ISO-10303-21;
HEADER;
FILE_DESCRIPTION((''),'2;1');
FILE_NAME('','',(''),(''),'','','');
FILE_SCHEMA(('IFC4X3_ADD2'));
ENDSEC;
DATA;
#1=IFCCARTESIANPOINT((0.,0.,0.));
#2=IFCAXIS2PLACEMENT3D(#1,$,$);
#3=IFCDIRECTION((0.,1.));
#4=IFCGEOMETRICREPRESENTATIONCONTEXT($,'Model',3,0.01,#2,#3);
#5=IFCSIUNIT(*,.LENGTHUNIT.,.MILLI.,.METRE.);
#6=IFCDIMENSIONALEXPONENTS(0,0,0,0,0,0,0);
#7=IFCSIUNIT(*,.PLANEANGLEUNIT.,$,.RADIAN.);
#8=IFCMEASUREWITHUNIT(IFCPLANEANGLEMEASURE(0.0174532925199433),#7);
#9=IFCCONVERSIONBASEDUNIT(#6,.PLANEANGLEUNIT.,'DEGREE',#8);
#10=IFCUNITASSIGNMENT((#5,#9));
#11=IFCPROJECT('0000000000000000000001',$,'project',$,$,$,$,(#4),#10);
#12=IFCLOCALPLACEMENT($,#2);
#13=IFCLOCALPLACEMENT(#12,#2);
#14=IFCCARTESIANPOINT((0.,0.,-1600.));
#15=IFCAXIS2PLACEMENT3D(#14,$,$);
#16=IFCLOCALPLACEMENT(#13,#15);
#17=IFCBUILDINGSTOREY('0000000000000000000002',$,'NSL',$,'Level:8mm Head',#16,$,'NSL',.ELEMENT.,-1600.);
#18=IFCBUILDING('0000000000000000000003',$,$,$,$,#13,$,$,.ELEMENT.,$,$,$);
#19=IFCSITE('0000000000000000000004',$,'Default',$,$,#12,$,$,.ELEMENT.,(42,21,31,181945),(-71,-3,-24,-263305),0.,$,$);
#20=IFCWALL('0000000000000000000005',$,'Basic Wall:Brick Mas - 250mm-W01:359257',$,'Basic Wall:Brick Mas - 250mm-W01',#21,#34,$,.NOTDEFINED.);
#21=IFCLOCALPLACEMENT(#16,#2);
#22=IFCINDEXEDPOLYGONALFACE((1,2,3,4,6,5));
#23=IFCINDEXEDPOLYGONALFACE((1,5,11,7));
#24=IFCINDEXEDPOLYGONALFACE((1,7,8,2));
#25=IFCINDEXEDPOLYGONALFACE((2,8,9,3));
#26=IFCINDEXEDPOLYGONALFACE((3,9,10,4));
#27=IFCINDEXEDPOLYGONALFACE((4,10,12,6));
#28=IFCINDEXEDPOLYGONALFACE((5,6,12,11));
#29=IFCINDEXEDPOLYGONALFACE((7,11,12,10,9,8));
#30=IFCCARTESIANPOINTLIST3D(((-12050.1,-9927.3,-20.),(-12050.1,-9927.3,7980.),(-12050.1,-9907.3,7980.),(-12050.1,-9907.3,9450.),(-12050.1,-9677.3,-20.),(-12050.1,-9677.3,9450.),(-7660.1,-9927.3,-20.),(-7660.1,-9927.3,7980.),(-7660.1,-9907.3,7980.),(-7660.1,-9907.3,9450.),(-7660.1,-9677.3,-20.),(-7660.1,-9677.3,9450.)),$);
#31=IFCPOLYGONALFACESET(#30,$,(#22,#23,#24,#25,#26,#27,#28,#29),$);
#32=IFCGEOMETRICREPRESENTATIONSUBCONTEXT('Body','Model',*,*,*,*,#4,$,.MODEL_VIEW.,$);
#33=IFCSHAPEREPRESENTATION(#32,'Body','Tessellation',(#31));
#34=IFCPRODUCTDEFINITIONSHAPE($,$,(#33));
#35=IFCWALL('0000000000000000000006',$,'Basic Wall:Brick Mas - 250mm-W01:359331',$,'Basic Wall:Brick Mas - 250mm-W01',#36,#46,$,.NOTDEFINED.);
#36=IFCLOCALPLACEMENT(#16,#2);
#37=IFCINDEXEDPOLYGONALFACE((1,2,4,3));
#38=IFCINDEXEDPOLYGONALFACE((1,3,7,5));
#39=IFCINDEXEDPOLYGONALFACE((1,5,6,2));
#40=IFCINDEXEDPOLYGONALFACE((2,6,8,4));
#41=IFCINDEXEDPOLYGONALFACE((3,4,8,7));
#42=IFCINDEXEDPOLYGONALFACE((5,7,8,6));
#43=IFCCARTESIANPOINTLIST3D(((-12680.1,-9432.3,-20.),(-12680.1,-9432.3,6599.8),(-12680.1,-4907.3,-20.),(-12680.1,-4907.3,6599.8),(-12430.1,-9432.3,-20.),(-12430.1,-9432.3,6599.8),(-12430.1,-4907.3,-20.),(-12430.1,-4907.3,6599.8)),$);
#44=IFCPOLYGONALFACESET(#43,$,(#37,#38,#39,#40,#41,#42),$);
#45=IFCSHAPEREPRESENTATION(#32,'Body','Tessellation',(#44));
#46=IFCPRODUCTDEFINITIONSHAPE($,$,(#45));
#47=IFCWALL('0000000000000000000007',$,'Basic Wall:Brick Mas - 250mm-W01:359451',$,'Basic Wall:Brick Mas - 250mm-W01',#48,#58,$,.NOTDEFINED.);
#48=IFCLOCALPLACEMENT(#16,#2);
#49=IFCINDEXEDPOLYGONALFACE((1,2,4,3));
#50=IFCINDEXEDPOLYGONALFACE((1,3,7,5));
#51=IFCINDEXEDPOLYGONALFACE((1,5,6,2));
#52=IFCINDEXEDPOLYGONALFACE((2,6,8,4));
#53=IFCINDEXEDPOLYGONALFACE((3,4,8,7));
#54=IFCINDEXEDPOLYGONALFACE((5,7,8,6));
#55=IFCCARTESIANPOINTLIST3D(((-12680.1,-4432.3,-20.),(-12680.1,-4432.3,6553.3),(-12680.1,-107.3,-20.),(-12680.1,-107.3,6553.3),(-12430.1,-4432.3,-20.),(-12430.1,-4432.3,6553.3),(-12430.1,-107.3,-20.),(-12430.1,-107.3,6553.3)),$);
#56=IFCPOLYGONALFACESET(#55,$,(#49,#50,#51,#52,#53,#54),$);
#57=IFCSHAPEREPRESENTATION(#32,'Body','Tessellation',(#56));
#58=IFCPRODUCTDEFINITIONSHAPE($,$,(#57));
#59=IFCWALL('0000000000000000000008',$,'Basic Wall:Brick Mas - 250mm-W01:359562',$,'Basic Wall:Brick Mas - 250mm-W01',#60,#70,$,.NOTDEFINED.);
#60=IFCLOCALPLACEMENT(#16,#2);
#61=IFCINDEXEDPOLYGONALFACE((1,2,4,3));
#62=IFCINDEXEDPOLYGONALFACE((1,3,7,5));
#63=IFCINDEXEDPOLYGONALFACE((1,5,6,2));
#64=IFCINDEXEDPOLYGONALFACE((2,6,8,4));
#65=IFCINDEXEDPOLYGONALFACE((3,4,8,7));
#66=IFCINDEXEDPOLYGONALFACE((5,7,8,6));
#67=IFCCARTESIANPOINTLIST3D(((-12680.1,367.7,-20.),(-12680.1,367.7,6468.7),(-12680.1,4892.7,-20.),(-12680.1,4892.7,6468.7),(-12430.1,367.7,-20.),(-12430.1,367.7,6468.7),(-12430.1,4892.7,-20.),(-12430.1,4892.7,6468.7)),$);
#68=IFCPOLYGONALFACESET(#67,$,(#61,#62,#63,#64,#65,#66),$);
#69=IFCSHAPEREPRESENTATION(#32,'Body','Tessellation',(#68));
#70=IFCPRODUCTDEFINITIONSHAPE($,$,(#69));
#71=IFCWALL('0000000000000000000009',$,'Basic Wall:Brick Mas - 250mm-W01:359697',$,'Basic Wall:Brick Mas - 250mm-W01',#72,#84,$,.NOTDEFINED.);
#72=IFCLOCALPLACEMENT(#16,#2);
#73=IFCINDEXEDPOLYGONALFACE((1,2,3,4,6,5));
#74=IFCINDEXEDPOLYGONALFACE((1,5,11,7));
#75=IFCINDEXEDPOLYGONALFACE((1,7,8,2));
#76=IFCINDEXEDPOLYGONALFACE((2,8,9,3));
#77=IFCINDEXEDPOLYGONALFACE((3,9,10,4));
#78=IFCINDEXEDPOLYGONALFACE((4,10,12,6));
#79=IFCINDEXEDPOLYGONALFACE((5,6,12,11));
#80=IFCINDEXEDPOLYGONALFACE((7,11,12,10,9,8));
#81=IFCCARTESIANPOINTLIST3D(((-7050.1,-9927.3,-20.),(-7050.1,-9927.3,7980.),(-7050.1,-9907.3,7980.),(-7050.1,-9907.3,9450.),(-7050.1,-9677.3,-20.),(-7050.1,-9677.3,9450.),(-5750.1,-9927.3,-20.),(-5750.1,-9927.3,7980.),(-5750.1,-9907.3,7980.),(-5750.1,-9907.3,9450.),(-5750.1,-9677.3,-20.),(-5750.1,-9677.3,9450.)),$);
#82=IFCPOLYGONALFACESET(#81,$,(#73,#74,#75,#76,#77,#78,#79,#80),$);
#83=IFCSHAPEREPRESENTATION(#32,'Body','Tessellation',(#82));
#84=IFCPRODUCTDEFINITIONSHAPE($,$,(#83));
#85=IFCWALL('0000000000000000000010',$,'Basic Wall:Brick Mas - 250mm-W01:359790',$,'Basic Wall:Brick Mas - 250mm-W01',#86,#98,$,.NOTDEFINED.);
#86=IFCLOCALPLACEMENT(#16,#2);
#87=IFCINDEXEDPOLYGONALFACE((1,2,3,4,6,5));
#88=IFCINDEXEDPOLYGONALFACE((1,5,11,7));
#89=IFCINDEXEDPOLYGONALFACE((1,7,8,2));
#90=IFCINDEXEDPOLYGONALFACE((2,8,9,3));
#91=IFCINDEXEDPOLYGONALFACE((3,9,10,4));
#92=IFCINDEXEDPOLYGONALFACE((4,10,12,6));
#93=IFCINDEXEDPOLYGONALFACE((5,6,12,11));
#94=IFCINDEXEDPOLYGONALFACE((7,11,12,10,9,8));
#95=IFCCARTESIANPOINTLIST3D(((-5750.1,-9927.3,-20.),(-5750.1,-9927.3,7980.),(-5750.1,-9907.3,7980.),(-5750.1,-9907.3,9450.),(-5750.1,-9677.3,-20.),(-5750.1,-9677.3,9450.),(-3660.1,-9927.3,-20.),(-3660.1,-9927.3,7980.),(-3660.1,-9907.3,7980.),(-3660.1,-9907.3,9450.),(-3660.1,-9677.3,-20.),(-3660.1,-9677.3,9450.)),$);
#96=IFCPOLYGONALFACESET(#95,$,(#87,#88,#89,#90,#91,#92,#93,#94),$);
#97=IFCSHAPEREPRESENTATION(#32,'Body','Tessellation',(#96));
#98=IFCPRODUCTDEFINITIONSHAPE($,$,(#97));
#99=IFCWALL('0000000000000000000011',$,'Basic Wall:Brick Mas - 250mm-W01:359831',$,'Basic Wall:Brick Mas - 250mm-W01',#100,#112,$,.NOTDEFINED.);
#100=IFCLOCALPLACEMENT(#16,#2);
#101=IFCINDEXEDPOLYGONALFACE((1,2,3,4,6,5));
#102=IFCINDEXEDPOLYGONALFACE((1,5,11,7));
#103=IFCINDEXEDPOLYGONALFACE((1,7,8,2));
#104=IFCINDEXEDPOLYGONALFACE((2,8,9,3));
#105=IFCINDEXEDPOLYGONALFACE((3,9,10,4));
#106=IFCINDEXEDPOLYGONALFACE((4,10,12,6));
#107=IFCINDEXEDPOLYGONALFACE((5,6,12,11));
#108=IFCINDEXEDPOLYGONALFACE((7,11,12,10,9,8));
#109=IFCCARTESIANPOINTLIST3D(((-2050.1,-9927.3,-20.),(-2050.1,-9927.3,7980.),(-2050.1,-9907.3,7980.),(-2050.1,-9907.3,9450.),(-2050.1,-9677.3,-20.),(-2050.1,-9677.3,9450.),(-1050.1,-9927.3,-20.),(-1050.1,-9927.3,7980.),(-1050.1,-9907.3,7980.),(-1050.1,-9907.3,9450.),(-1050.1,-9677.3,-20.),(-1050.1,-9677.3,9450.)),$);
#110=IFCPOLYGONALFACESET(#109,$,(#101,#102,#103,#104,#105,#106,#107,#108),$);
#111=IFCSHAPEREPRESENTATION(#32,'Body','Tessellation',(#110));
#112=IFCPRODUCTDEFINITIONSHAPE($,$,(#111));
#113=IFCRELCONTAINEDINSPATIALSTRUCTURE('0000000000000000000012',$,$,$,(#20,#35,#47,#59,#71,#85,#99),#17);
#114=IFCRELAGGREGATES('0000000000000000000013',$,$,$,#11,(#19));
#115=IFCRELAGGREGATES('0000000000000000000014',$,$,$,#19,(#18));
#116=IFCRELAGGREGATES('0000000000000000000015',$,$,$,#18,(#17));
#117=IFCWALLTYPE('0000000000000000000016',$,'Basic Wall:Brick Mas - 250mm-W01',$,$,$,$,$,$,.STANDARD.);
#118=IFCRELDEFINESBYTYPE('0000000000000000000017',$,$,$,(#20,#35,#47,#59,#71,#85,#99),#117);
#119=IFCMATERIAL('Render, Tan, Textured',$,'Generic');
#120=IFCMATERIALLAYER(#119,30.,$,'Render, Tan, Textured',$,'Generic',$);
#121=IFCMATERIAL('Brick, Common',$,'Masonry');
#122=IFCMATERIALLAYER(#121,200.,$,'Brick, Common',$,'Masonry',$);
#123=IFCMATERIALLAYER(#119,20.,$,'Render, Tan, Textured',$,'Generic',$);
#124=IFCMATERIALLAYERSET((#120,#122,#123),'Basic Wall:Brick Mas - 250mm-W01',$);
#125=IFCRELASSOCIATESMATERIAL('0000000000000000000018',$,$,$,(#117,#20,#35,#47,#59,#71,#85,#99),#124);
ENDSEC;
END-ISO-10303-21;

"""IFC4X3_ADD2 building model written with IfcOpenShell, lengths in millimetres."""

from ifc_helpers import new_model, entity, si_unit, converted_unit, direction, frame, frame_2d, origin, place, context, subcontext, project, spatial, polyline, rectangle, extrude, clip, bounded_halfspace, material, layer, layer_set, type_object, element, save


model = new_model("IFC4X3_ADD2")

# Units and contexts
model_context = context("Model", 3, precision=0.01, world=origin(), true_north=direction((0.0, 1.0)))
body_context = subcontext(model_context, "Body", "Model", "MODEL_VIEW")
ifc_project = project(units=[si_unit("LENGTHUNIT", "METRE", prefix="MILLI"), converted_unit("PLANEANGLEUNIT", "DEGREE", entity("IfcPlaneAngleMeasure", 0.0174532925199433), si_unit("PLANEANGLEUNIT", "RADIAN"), dimensions=[0, 0, 0, 0, 0, 0, 0])], contexts=[model_context])

# Site, building, storey
site_placement = place(None, origin())
site = spatial("IfcSite", under=ifc_project, at=site_placement, Name="Default", CompositionType="ELEMENT", RefLatitude=(42, 21, 31, 181945), RefLongitude=(-71, -3, -24, -263305), RefElevation=0.0)
building_placement = place(site_placement, origin())
building = spatial("IfcBuilding", under=site, at=building_placement, CompositionType="ELEMENT")
storey_placement = place(building_placement, frame((0.0, 0.0, -1600.0)))
storey = spatial("IfcBuildingStorey", under=building, at=storey_placement, Name="NSL", ObjectType="Level:8mm Head", LongName="NSL", CompositionType="ELEMENT", Elevation=-1600.0)

# Shared definitions
ifc_material_1 = material(Name="Render, Tan, Textured", Category="Generic")
ifc_layer_1 = layer(ifc_material_1, 30.0, Name="Render, Tan, Textured", Category="Generic")
ifc_material_2 = material(Name="Brick, Common", Category="Masonry")
ifc_layer_2 = layer(ifc_material_2, 200.0, Name="Brick, Common", Category="Masonry")
ifc_layer_3 = layer(ifc_material_1, 20.0, Name="Render, Tan, Textured", Category="Generic")
ifc_layer_set = layer_set([ifc_layer_1, ifc_layer_2, ifc_layer_3], Name="Basic Wall:Brick Mas - 250mm-W01")
wall_type = type_object("IfcWallType", Name="Basic Wall:Brick Mas - 250mm-W01", PredefinedType="STANDARD", material=ifc_layer_set)

# Walls
wall_1_placement = place(storey_placement, frame((-7660.1, -9802.3, -20.0), z_axis=(0.0, 0.0, 1.0), x_axis=(-1.0, 0.0, 0.0)))
element("IfcWall", 1, at=wall_1_placement, inside=storey, type_object=wall_type, material=ifc_layer_set, Name="Basic Wall:Brick Mas - 250mm-W01:359257", ObjectType="Basic Wall:Brick Mas - 250mm-W01", PredefinedType="NOTDEFINED", context=body_context, shape_type="Clipping", body=[
    clip(clip(extrude(rectangle(XDim=4390.0, YDim=250.0, at=frame_2d((2195.0, 0.0), x_axis=(-1.0, 0.0))), origin(), (0.0, 0.0, 1.0), 9470.0), bounded_halfspace(frame((0.0, -125.0, 9470.0), z_axis=(0.0, 0.0, -1.0), x_axis=(0.0, 1.0, 0.0)), True, frame((0.0, -125.0, 9470.0)), polyline([(0.0, 0.0), (4390.0, 0.0), (4390.0, 230.0), (0.0, 230.0), (0.0, 0.0)]))), bounded_halfspace(frame((4390.0, 105.0, 8000.0), z_axis=(0.0, 0.0, 1.0), x_axis=(0.0, 1.0, 0.0)), False, frame((4390.0, 105.0, 8000.0)), polyline([(0.0, 0.0), (0.0, 20.0), (-4390.0, 20.0), (-4390.0, 0.0), (0.0, 0.0)]))),
])
wall_2_placement = place(storey_placement, frame((-12555.1, -9432.3, -20.0), z_axis=(0.0, 0.0, 1.0), x_axis=(0.0, 1.0, 0.0)))
element("IfcWall", 2, at=wall_2_placement, inside=storey, type_object=wall_type, material=ifc_layer_set, Name="Basic Wall:Brick Mas - 250mm-W01:359331", ObjectType="Basic Wall:Brick Mas - 250mm-W01", PredefinedType="NOTDEFINED", context=body_context, shape_type="SweptSolid", body=[
    extrude(rectangle(XDim=4525.0, YDim=250.0, at=frame_2d((2262.5, 0.0), x_axis=(-1.0, 0.0))), origin(), (0.0, 0.0, 1.0), 6619.8),
])
wall_3_placement = place(storey_placement, frame((-12555.1, -4432.3, -20.0), z_axis=(0.0, 0.0, 1.0), x_axis=(0.0, 1.0, 0.0)))
element("IfcWall", 3, at=wall_3_placement, inside=storey, type_object=wall_type, material=ifc_layer_set, Name="Basic Wall:Brick Mas - 250mm-W01:359451", ObjectType="Basic Wall:Brick Mas - 250mm-W01", PredefinedType="NOTDEFINED", context=body_context, shape_type="SweptSolid", body=[
    extrude(rectangle(XDim=4325.0, YDim=250.0, at=frame_2d((2162.5, 0.0), x_axis=(-1.0, 0.0))), origin(), (0.0, 0.0, 1.0), 6573.3),
])
wall_4_placement = place(storey_placement, frame((-12555.1, 367.7, -20.0), z_axis=(0.0, 0.0, 1.0), x_axis=(0.0, 1.0, 0.0)))
element("IfcWall", 4, at=wall_4_placement, inside=storey, type_object=wall_type, material=ifc_layer_set, Name="Basic Wall:Brick Mas - 250mm-W01:359562", ObjectType="Basic Wall:Brick Mas - 250mm-W01", PredefinedType="NOTDEFINED", context=body_context, shape_type="SweptSolid", body=[
    extrude(rectangle(XDim=4525.0, YDim=250.0, at=frame_2d((2262.5, 0.0), x_axis=(-1.0, 0.0))), origin(), (0.0, 0.0, 1.0), 6488.7),
])
wall_5_placement = place(storey_placement, frame((-5750.1, -9802.3, -20.0), z_axis=(0.0, 0.0, 1.0), x_axis=(-1.0, 0.0, 0.0)))
element("IfcWall", 5, at=wall_5_placement, inside=storey, type_object=wall_type, material=ifc_layer_set, Name="Basic Wall:Brick Mas - 250mm-W01:359697", ObjectType="Basic Wall:Brick Mas - 250mm-W01", PredefinedType="NOTDEFINED", context=body_context, shape_type="Clipping", body=[
    clip(clip(extrude(rectangle(XDim=1300.0, YDim=250.0, at=frame_2d((650.0, 0.0), x_axis=(-1.0, 0.0))), origin(), (0.0, 0.0, 1.0), 9470.0), bounded_halfspace(frame((0.0, -125.0, 9470.0), z_axis=(0.0, 0.0, -1.0), x_axis=(0.0, 1.0, 0.0)), True, frame((0.0, -125.0, 9470.0)), polyline([(0.0, 0.0), (1300.0, 0.0), (1300.0, 230.0), (0.0, 230.0), (0.0, 0.0)]))), bounded_halfspace(frame((1300.0, 105.0, 8000.0), z_axis=(0.0, 0.0, 1.0), x_axis=(0.0, 1.0, 0.0)), False, frame((1300.0, 105.0, 8000.0)), polyline([(0.0, 0.0), (0.0, 20.0), (-1300.0, 20.0), (-1300.0, 0.0), (0.0, 0.0)]))),
])
wall_6_placement = place(storey_placement, frame((-3660.1, -9802.3, -20.0), z_axis=(0.0, 0.0, 1.0), x_axis=(-1.0, 0.0, 0.0)))
element("IfcWall", 6, at=wall_6_placement, inside=storey, type_object=wall_type, material=ifc_layer_set, Name="Basic Wall:Brick Mas - 250mm-W01:359790", ObjectType="Basic Wall:Brick Mas - 250mm-W01", PredefinedType="NOTDEFINED", context=body_context, shape_type="Clipping", body=[
    clip(clip(extrude(rectangle(XDim=2090.0, YDim=250.0, at=frame_2d((1045.0, 0.0), x_axis=(-1.0, 0.0))), origin(), (0.0, 0.0, 1.0), 9470.0), bounded_halfspace(frame((0.0, -125.0, 9470.0), z_axis=(0.0, 0.0, -1.0), x_axis=(0.0, 1.0, 0.0)), True, frame((0.0, -125.0, 9470.0)), polyline([(0.0, 0.0), (2090.0, 0.0), (2090.0, 230.0), (0.0, 230.0), (0.0, 0.0)]))), bounded_halfspace(frame((2090.0, 105.0, 8000.0), z_axis=(0.0, 0.0, 1.0), x_axis=(0.0, 1.0, 0.0)), False, frame((2090.0, 105.0, 8000.0)), polyline([(0.0, 0.0), (0.0, 20.0), (-2090.0, 20.0), (-2090.0, 0.0), (0.0, 0.0)]))),
])
wall_7_placement = place(storey_placement, frame((-1050.1, -9802.3, -20.0), z_axis=(0.0, 0.0, 1.0), x_axis=(-1.0, 0.0, 0.0)))
element("IfcWall", 7, at=wall_7_placement, inside=storey, type_object=wall_type, material=ifc_layer_set, Name="Basic Wall:Brick Mas - 250mm-W01:359831", ObjectType="Basic Wall:Brick Mas - 250mm-W01", PredefinedType="NOTDEFINED", context=body_context, shape_type="Clipping", body=[
    clip(clip(extrude(rectangle(XDim=1000.0, YDim=250.0, at=frame_2d((500.0, 0.0), x_axis=(-1.0, 0.0))), origin(), (0.0, 0.0, 1.0), 9470.0), bounded_halfspace(frame((0.0, -125.0, 9470.0), z_axis=(0.0, 0.0, -1.0), x_axis=(0.0, 1.0, 0.0)), True, frame((0.0, -125.0, 9470.0)), polyline([(0.0, 0.0), (1000.0, 0.0), (1000.0, 230.0), (0.0, 230.0), (0.0, 0.0)]))), bounded_halfspace(frame((1000.0, 105.0, 8000.0), z_axis=(0.0, 0.0, 1.0), x_axis=(0.0, 1.0, 0.0)), False, frame((1000.0, 105.0, 8000.0)), polyline([(0.0, 0.0), (0.0, 20.0), (-1000.0, 20.0), (-1000.0, 0.0), (0.0, 0.0)]))),
])

save(model, "model.ifc")
